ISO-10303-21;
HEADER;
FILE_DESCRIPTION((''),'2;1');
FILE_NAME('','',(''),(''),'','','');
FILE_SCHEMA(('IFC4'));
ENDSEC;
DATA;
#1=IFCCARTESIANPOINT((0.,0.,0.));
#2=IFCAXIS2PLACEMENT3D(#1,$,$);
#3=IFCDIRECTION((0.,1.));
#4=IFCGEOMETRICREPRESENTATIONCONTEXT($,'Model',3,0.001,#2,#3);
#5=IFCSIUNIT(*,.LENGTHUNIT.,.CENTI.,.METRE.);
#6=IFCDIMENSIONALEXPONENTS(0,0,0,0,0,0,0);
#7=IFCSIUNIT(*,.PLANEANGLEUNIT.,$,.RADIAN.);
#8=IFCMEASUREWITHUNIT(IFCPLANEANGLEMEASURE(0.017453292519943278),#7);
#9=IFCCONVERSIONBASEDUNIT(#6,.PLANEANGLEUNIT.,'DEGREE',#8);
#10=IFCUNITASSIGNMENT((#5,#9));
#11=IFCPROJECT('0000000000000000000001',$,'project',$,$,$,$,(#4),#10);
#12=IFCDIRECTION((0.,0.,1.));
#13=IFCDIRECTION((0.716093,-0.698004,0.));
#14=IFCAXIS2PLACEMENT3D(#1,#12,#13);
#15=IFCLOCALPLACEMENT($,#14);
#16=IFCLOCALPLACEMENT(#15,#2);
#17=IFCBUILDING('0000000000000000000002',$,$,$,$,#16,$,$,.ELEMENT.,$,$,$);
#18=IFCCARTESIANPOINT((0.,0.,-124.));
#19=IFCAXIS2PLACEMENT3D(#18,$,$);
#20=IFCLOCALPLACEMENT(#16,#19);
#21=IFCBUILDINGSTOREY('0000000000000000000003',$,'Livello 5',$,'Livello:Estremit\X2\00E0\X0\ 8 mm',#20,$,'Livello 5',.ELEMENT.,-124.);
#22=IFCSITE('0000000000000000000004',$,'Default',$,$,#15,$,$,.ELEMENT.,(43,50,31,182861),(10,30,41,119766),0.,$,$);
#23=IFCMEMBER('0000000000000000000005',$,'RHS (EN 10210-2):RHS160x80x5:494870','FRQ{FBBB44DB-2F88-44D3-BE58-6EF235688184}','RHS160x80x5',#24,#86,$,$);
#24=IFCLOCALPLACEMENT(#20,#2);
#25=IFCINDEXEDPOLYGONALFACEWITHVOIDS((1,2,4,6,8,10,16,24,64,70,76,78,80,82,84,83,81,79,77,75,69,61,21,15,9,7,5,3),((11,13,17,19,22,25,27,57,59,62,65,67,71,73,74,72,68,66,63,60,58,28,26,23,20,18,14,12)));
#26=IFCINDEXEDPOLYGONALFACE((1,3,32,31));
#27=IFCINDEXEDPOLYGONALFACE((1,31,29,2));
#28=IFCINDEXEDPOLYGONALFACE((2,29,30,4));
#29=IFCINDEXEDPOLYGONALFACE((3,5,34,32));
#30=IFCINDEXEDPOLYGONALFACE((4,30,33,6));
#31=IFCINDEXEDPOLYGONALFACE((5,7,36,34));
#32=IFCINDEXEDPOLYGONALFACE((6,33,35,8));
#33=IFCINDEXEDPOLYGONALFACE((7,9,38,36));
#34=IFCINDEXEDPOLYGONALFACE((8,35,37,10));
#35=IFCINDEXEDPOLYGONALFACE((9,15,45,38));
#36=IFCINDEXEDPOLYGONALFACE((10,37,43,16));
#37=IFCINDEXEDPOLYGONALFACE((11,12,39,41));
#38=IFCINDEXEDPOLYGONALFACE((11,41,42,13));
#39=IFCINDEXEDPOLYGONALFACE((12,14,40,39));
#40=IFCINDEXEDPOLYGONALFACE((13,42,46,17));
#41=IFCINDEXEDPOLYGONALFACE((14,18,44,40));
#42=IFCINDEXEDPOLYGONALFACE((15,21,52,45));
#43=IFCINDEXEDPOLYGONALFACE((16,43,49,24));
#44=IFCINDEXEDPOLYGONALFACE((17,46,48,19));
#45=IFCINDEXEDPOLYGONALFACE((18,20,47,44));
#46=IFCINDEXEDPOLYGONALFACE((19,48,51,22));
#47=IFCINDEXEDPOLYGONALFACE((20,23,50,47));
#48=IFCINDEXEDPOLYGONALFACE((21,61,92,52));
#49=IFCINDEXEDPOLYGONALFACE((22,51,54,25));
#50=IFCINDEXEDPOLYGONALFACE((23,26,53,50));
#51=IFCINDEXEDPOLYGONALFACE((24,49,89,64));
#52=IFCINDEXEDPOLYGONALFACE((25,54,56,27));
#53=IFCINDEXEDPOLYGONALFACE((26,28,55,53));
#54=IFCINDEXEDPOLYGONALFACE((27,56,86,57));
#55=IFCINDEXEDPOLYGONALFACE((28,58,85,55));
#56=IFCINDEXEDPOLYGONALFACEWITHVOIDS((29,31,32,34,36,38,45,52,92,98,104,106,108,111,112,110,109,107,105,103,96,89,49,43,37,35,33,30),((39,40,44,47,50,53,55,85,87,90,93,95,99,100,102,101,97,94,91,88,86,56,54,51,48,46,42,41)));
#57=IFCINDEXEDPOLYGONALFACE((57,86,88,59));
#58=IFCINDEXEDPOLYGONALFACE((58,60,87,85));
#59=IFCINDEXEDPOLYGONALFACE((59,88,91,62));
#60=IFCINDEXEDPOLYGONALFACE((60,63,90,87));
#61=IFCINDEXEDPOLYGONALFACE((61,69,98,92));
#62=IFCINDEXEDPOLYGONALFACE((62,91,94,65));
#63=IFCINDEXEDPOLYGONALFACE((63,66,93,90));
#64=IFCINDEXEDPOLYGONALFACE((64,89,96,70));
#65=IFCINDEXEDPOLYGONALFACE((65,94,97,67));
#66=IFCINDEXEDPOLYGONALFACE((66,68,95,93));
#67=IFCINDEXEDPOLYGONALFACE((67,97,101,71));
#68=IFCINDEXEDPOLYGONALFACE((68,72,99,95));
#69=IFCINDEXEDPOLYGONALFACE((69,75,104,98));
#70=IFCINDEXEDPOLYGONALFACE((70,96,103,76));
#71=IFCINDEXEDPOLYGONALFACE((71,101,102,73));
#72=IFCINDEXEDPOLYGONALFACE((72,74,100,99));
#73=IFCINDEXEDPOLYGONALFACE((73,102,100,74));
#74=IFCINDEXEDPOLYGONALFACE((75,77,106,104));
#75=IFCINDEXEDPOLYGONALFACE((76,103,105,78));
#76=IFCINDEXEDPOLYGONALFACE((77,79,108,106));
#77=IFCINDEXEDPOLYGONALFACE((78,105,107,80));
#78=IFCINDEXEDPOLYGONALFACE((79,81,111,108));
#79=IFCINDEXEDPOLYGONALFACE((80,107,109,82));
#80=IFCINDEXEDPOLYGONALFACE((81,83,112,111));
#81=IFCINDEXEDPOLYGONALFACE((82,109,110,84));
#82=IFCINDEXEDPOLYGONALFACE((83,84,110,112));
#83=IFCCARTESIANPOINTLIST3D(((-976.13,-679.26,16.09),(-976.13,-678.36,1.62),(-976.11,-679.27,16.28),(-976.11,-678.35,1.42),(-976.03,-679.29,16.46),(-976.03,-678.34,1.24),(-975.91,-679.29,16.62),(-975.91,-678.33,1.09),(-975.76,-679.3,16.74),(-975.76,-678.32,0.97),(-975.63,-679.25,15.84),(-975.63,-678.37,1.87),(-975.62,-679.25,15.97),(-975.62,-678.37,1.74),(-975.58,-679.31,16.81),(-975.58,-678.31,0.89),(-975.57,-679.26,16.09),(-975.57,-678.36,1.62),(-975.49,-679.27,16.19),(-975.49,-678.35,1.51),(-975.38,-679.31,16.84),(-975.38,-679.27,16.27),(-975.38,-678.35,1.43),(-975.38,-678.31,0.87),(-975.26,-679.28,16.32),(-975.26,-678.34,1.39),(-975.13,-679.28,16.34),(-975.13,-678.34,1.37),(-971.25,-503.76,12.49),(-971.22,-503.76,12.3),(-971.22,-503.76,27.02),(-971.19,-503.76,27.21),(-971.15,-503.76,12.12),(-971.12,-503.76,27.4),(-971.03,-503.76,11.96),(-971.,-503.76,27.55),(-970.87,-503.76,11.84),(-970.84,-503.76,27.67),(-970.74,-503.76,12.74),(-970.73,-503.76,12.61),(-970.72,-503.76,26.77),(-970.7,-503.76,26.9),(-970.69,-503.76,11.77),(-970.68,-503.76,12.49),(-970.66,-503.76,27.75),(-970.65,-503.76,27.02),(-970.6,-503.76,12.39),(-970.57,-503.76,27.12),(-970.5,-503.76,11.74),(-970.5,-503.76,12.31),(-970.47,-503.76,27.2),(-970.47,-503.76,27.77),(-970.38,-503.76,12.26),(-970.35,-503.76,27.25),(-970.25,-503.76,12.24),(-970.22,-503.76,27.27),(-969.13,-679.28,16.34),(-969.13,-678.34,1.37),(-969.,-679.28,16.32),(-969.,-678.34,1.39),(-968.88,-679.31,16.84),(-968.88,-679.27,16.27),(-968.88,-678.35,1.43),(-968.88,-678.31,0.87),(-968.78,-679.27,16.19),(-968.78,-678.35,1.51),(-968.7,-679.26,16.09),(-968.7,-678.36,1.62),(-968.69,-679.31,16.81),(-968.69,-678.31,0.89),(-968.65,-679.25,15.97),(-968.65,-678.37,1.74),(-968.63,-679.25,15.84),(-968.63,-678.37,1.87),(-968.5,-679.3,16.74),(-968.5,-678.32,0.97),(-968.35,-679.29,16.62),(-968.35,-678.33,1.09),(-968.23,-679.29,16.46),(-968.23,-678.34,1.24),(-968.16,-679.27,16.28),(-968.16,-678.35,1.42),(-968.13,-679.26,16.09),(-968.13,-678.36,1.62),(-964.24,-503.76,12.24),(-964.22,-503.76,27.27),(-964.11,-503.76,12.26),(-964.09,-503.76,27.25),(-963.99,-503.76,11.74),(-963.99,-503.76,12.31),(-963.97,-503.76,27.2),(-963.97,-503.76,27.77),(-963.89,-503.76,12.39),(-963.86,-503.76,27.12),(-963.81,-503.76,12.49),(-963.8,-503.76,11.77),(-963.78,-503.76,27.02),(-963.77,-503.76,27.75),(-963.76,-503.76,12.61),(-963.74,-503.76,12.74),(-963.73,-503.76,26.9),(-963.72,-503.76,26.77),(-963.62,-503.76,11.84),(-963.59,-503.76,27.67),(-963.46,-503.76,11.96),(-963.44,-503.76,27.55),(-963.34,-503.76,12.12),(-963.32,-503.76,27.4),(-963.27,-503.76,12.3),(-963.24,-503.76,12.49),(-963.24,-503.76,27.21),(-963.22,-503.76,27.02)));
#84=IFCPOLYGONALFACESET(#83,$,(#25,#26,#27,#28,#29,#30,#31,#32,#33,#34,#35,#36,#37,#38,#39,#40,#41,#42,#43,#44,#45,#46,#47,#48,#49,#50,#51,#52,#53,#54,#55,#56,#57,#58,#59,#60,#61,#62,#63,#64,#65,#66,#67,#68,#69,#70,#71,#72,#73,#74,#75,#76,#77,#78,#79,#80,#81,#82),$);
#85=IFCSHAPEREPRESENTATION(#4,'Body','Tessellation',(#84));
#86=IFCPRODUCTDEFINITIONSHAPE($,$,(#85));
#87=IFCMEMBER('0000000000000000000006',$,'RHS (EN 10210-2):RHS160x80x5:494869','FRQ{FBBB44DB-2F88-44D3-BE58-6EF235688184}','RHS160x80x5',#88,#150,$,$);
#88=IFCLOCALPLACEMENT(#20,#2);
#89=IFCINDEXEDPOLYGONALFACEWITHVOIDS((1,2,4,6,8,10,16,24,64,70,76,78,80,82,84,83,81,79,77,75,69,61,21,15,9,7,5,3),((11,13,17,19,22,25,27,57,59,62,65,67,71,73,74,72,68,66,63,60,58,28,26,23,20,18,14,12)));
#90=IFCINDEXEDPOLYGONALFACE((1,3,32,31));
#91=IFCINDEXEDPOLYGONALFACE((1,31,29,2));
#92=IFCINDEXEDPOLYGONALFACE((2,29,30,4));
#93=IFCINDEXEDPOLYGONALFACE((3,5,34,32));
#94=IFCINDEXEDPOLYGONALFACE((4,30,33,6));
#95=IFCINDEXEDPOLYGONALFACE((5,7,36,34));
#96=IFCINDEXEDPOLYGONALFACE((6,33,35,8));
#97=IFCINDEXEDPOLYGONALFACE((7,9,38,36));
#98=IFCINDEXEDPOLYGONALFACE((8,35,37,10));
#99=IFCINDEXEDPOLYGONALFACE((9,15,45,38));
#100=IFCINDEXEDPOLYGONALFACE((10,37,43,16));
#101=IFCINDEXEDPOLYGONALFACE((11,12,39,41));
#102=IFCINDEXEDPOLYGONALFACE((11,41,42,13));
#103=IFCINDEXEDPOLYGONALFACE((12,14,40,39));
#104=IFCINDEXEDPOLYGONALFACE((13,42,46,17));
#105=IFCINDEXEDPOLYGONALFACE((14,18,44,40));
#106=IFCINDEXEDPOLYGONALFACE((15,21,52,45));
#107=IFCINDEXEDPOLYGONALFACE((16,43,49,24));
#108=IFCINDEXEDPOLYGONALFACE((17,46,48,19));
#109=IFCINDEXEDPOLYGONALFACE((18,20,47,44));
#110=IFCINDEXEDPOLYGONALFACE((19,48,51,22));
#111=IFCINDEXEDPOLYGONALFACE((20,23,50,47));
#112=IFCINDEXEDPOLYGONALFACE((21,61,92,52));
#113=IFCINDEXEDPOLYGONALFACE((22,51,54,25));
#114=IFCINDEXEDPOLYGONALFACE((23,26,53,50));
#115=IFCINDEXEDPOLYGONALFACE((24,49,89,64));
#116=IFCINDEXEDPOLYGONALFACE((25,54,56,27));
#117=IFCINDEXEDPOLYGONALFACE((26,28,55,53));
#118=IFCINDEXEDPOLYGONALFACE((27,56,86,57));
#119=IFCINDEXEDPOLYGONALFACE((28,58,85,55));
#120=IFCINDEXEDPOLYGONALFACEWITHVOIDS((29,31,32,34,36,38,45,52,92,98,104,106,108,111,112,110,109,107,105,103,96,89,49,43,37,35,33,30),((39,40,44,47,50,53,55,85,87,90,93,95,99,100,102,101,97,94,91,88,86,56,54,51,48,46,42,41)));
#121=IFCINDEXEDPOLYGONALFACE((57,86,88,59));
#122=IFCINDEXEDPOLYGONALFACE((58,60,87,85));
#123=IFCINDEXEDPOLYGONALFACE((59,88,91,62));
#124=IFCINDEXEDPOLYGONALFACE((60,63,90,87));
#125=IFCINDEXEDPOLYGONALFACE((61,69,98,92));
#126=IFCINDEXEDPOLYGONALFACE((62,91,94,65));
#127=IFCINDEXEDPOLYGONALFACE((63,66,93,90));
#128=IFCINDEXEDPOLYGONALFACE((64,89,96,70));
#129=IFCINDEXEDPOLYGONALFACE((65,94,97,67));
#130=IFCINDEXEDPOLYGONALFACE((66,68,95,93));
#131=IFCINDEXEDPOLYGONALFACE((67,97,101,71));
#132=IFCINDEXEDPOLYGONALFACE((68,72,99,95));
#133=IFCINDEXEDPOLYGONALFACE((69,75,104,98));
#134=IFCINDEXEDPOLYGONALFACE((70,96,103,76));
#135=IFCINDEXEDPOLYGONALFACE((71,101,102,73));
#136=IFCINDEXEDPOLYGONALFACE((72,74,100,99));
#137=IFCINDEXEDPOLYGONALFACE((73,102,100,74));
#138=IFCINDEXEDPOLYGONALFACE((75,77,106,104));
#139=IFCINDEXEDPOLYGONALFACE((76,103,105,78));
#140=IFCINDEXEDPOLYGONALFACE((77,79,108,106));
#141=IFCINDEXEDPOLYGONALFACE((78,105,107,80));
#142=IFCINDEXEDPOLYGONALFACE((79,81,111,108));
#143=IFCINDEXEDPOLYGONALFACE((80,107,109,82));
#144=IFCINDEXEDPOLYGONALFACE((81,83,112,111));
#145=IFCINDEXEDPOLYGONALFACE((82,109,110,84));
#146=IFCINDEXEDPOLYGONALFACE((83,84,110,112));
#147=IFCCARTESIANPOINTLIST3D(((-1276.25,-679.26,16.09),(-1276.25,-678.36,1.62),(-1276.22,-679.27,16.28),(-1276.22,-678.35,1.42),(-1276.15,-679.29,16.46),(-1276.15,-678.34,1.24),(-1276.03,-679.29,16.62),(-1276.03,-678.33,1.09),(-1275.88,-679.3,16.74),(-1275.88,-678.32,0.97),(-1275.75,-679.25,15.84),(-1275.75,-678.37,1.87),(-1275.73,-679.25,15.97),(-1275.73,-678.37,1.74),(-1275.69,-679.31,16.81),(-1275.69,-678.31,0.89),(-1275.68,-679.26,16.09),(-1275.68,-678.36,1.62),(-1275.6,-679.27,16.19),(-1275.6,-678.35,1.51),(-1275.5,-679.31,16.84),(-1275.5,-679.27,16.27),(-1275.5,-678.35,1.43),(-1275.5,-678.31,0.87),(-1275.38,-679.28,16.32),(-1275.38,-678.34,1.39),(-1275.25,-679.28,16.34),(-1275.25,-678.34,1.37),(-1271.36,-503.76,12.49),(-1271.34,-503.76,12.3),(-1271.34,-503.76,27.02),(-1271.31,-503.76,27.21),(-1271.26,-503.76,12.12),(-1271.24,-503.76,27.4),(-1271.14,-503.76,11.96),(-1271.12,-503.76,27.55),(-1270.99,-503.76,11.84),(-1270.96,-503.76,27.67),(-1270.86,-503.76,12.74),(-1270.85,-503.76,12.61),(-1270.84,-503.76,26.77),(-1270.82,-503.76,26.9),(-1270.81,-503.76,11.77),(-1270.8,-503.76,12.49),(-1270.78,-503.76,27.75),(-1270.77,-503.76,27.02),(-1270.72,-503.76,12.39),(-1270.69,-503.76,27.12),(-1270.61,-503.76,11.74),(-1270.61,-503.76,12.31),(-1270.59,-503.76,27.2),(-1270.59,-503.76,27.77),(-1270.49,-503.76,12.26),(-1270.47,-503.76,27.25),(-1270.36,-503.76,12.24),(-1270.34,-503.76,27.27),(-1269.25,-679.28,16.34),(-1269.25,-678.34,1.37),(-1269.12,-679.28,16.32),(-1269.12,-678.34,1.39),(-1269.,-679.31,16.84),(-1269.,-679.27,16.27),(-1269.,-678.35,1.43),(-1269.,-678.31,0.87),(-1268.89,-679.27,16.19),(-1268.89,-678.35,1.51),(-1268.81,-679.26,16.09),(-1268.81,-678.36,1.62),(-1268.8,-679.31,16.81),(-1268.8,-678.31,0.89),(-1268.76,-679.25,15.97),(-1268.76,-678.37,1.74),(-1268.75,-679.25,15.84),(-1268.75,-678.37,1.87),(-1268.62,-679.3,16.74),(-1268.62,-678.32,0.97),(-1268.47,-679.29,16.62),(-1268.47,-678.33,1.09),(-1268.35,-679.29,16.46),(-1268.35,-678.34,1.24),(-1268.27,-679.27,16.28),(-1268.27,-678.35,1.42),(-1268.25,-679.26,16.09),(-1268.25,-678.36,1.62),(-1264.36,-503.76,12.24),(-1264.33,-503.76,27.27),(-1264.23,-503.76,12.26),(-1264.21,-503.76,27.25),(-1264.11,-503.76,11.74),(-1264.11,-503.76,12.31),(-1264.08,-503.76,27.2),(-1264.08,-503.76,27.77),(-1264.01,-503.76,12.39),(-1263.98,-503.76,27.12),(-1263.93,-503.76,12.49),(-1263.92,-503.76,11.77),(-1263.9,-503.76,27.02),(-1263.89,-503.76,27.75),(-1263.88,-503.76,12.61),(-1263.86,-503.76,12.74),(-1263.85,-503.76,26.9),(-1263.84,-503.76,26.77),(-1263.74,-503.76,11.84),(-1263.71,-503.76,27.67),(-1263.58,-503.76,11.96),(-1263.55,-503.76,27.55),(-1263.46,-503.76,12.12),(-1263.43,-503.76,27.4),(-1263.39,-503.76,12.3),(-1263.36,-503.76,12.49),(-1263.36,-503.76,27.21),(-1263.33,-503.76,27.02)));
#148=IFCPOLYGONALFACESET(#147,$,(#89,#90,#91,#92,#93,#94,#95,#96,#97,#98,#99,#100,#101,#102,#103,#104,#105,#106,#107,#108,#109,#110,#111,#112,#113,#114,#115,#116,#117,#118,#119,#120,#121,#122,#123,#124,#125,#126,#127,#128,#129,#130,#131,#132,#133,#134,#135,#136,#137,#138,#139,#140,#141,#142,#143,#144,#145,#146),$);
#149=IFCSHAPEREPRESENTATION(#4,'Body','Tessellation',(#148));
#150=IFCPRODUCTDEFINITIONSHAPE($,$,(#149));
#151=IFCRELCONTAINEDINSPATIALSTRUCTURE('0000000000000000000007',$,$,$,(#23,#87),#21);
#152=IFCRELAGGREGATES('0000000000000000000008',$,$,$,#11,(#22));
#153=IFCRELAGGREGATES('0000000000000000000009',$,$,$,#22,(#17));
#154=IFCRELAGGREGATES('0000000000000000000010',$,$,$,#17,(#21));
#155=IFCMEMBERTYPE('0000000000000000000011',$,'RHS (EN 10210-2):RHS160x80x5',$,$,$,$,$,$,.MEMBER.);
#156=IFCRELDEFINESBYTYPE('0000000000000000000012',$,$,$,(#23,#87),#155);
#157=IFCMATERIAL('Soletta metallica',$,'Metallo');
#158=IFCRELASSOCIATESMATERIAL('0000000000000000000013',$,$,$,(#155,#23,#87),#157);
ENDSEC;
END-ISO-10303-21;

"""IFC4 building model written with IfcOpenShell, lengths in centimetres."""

from ifc_helpers import new_model, entity, si_unit, converted_unit, direction, frame, origin, origin_2d, place, context, project, spatial, hollow_rectangle, extrude, clip, halfspace, material, type_object, element, save


model = new_model("IFC4")

# Units and contexts
model_context = context("Model", 3, precision=0.001, world=origin(), true_north=direction((0.0, 1.0)))
ifc_project = project(units=[si_unit("LENGTHUNIT", "METRE", prefix="CENTI"), converted_unit("PLANEANGLEUNIT", "DEGREE", entity("IfcPlaneAngleMeasure", 0.017453292519943278), si_unit("PLANEANGLEUNIT", "RADIAN"), dimensions=[0, 0, 0, 0, 0, 0, 0])], contexts=[model_context])

# Site, building, storey
site_placement = place(None, frame((0.0, 0.0, 0.0), z_axis=(0.0, 0.0, 1.0), x_axis=(0.716093, -0.698004, 0.0)))
site = spatial("IfcSite", under=ifc_project, at=site_placement, Name="Default", CompositionType="ELEMENT", RefLatitude=(43, 50, 31, 182861), RefLongitude=(10, 30, 41, 119766), RefElevation=0.0)
building_placement = place(site_placement, origin())
building = spatial("IfcBuilding", under=site, at=building_placement, CompositionType="ELEMENT")
storey_placement = place(building_placement, frame((0.0, 0.0, -124.0)))
storey = spatial("IfcBuildingStorey", under=building, at=storey_placement, Name="Livello 5", ObjectType="Livello:Estremità 8 mm", LongName="Livello 5", CompositionType="ELEMENT", Elevation=-124.0)

# Shared definitions
ifc_material_1 = material(Name="Soletta metallica", Category="Metallo")

# Members
member_type_1 = type_object("IfcMemberType", Name="RHS (EN 10210-2):RHS160x80x5", PredefinedType="MEMBER", material=ifc_material_1)
member_1_placement = place(storey_placement, frame((-973.22, -717.68, 6.43), z_axis=(-0.027926, -0.997677, -0.062135), x_axis=(0.99961, -0.027872, -0.001736)))
element("IfcMember", 1, at=member_1_placement, inside=storey, type_object=member_type_1, material=ifc_material_1, Name="RHS (EN 10210-2):RHS160x80x5:494870", Description="FRQ{FBBB44DB-2F88-44D3-BE58-6EF235688184}", ObjectType="RHS160x80x5", context=model_context, shape_type="Clipping", body=[
    clip(clip(extrude(hollow_rectangle(XDim=8.0, YDim=16.0, WallThickness=0.5, InnerFilletRadius=0.5, OuterFilletRadius=0.75, at=origin_2d()), origin(), (0.0, 0.0, -1.0), 242.93), halfspace(frame((966.85, 102.35, -247.91), z_axis=(0.02798, 0.062159, 0.997674), x_axis=(0.999608, -0.00174, -0.027926)), True)), halfspace(frame((971.88, 70.96, -66.1), z_axis=(-0.027926, 0.000109, -0.99961), x_axis=(-0.999608, 0.00174, 0.027926)), True)),
])
member_2_placement = place(storey_placement, frame((-1273.34, -717.68, 6.43), z_axis=(-0.027926, -0.997677, -0.062135), x_axis=(0.99961, -0.027872, -0.001736)))
element("IfcMember", 2, at=member_2_placement, inside=storey, type_object=member_type_1, material=ifc_material_1, Name="RHS (EN 10210-2):RHS160x80x5:494869", Description="FRQ{FBBB44DB-2F88-44D3-BE58-6EF235688184}", ObjectType="RHS160x80x5", context=model_context, shape_type="Clipping", body=[
    clip(clip(extrude(hollow_rectangle(XDim=8.0, YDim=16.0, WallThickness=0.5, InnerFilletRadius=0.5, OuterFilletRadius=0.75, at=origin_2d()), origin(), (0.0, 0.0, -1.0), 242.93), halfspace(frame((1266.85, 101.83, -256.29), z_axis=(0.02798, 0.062159, 0.997674), x_axis=(0.999608, -0.00174, -0.027926)), True)), halfspace(frame((1271.88, 70.44, -74.48), z_axis=(-0.027926, 0.000109, -0.99961), x_axis=(-0.999608, 0.00174, 0.027926)), True)),
])

save(model, "model.ifc")
